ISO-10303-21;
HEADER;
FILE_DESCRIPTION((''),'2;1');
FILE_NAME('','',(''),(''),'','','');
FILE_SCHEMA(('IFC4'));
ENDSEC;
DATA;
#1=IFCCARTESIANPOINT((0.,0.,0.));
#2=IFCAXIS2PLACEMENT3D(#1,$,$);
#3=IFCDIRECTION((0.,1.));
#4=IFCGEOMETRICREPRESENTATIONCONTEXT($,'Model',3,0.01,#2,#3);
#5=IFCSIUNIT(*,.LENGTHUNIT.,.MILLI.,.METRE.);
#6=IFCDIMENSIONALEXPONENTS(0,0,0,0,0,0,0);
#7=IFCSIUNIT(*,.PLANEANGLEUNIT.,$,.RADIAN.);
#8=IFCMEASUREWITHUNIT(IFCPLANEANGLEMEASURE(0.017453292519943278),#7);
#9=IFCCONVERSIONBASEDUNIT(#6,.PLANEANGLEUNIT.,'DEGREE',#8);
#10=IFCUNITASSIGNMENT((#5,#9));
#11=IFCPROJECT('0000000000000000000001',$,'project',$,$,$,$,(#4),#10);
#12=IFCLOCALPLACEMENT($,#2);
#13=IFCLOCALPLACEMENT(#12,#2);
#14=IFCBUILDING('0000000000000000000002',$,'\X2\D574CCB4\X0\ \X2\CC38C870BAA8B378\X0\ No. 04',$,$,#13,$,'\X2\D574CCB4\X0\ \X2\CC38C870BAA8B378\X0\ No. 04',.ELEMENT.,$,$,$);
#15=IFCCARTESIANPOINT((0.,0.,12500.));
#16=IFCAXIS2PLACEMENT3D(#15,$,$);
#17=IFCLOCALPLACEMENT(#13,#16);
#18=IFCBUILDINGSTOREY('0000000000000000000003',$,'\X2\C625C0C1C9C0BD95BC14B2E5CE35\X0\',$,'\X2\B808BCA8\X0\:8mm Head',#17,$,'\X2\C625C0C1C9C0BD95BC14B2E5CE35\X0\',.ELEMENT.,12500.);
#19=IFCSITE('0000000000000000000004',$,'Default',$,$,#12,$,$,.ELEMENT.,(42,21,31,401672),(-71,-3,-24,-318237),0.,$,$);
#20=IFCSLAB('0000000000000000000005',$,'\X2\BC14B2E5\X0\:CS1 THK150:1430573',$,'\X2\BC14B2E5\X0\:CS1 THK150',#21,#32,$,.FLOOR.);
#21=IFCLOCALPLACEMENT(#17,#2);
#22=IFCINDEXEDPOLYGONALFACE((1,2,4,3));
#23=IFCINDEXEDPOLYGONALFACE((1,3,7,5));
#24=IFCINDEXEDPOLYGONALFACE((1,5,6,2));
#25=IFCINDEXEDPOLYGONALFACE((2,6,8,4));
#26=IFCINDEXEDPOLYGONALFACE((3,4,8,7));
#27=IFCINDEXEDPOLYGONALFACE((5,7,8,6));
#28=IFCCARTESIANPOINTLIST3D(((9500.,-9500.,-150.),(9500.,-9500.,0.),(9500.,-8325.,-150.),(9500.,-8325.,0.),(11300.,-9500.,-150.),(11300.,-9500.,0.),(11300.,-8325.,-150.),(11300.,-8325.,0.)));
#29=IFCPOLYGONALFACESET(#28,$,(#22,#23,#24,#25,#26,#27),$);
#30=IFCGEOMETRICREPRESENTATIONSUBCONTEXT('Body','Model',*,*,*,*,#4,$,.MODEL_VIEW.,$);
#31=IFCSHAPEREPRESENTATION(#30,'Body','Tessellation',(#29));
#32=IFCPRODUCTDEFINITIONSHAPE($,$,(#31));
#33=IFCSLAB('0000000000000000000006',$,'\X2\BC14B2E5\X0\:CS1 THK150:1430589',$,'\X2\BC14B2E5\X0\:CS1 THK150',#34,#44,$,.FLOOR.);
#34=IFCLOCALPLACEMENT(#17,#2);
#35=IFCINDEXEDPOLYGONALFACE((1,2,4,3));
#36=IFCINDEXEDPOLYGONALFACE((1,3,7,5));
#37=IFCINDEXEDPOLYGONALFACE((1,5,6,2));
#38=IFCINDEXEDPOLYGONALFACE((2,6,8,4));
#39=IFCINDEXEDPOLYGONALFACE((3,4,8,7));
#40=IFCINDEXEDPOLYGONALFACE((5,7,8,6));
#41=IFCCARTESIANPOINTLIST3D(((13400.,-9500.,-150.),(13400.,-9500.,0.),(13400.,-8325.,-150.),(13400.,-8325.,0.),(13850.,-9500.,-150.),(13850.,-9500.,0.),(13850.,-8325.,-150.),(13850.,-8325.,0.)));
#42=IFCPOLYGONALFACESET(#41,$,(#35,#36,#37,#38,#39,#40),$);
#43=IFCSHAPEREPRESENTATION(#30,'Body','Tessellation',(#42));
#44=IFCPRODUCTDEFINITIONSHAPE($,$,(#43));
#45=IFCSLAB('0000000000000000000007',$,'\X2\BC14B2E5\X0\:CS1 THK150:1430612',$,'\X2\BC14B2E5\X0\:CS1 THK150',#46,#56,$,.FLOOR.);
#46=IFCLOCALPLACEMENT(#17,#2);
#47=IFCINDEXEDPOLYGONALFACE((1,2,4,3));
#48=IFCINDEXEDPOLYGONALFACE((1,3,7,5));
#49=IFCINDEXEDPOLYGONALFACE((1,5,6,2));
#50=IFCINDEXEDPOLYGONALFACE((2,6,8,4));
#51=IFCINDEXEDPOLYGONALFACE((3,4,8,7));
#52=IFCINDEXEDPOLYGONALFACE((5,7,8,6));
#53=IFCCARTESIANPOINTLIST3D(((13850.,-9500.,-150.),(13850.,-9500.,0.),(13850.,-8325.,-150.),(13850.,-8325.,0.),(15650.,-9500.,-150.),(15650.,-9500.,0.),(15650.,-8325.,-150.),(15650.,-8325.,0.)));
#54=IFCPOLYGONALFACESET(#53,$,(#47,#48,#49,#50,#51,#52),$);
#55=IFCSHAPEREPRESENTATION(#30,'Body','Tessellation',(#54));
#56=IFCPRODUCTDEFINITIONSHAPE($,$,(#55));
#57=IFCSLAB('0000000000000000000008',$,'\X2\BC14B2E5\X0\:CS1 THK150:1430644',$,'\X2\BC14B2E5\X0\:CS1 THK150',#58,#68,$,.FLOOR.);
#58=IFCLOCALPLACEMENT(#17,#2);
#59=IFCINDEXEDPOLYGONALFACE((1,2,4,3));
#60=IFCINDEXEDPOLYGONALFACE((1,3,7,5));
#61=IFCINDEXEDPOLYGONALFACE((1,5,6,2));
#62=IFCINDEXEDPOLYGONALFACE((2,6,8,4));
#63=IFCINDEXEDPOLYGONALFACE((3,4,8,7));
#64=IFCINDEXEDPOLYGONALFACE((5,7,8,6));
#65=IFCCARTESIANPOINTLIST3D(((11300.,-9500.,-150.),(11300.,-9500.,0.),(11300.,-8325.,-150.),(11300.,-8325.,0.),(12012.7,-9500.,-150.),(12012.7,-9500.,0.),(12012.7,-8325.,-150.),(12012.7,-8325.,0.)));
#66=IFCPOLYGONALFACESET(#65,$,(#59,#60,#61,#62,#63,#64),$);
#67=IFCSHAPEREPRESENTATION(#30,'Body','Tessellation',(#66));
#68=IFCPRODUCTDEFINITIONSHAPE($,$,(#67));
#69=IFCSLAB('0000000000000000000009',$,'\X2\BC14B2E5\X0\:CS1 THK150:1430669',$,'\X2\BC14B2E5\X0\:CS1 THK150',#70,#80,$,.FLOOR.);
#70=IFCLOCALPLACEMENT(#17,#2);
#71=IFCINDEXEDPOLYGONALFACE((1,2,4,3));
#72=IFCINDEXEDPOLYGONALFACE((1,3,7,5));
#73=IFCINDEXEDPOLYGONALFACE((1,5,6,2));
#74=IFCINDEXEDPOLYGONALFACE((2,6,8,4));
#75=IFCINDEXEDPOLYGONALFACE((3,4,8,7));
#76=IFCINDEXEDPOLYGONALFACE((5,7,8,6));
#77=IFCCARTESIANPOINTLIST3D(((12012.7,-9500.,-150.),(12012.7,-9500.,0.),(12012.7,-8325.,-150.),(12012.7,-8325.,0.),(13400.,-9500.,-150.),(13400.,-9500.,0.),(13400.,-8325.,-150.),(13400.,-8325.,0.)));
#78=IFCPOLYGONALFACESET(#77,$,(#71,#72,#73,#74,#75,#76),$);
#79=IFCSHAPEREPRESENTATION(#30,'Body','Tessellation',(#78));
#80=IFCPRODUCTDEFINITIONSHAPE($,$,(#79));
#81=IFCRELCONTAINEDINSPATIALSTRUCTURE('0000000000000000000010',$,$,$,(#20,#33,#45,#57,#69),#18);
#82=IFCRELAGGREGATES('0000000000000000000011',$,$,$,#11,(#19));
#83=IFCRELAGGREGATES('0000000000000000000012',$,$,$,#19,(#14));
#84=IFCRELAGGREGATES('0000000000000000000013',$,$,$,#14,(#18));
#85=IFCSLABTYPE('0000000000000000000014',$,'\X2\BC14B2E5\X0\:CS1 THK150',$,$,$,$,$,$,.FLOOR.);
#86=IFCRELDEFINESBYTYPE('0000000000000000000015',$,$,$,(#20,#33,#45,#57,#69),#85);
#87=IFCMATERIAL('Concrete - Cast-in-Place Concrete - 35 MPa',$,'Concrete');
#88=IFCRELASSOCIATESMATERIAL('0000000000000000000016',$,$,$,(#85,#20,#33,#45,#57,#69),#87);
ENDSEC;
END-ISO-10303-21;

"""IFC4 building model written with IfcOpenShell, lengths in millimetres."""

from ifc_helpers import new_model, entity, si_unit, converted_unit, direction, frame, origin, place, context, subcontext, project, spatial, indexed_curve, outline, extrude, material, type_object, element, save


model = new_model("IFC4")

# Units and contexts
model_context = context("Model", 3, precision=0.01, world=origin(), true_north=direction((0.0, 1.0)))
body_context = subcontext(model_context, "Body", "Model", "MODEL_VIEW")
ifc_project = project(units=[si_unit("LENGTHUNIT", "METRE", prefix="MILLI"), converted_unit("PLANEANGLEUNIT", "DEGREE", entity("IfcPlaneAngleMeasure", 0.017453292519943278), si_unit("PLANEANGLEUNIT", "RADIAN"), dimensions=[0, 0, 0, 0, 0, 0, 0])], contexts=[model_context])

# Site, building, storey
site_placement = place(None, origin())
site = spatial("IfcSite", under=ifc_project, at=site_placement, Name="Default", CompositionType="ELEMENT", RefLatitude=(42, 21, 31, 401672), RefLongitude=(-71, -3, -24, -318237), RefElevation=0.0)
building_placement = place(site_placement, origin())
building = spatial("IfcBuilding", under=site, at=building_placement, Name="해체 참조모델 No. 04", LongName="해체 참조모델 No. 04", CompositionType="ELEMENT")
storey_placement = place(building_placement, frame((0.0, 0.0, 12500.0)))
storey = spatial("IfcBuildingStorey", under=building, at=storey_placement, Name="옥상지붕바닥층", ObjectType="레벨:8mm Head", LongName="옥상지붕바닥층", CompositionType="ELEMENT", Elevation=12500.0)

# Slabs
ifc_material = material(Name="Concrete - Cast-in-Place Concrete - 35 MPa", Category="Concrete")
slab_type_1 = type_object("IfcSlabType", Name="바닥:CS1 THK150", PredefinedType="FLOOR", material=ifc_material)
slab_1_placement = place(storey_placement, origin())
element("IfcSlab", 1, at=slab_1_placement, inside=storey, type_object=slab_type_1, material=ifc_material, Name="바닥:CS1 THK150:1430573", ObjectType="바닥:CS1 THK150", PredefinedType="FLOOR", context=body_context, shape_type="SweptSolid", body=[
    extrude(outline(indexed_curve([(-587.5, -900.0), (587.5, -900.0), (587.5, 900.0), (-587.5, 900.0), (-587.5, -900.0)], self_intersect=False)), frame((10400.0, -8912.5, 0.0), z_axis=(0.0, 0.0, -1.0), x_axis=(0.0, 1.0, 0.0)), (0.0, 0.0, 1.0), 150.0),
])
slab_2_placement = place(storey_placement, origin())
element("IfcSlab", 2, at=slab_2_placement, inside=storey, type_object=slab_type_1, material=ifc_material, Name="바닥:CS1 THK150:1430589", ObjectType="바닥:CS1 THK150", PredefinedType="FLOOR", context=body_context, shape_type="SweptSolid", body=[
    extrude(outline(indexed_curve([(-587.5, -225.0), (587.5, -225.0), (587.5, 225.0), (-587.5, 225.0), (-587.5, -225.0)], self_intersect=False)), frame((13625.0, -8912.5, 0.0), z_axis=(0.0, 0.0, -1.0), x_axis=(0.0, 1.0, 0.0)), (0.0, 0.0, 1.0), 150.0),
])
slab_3_placement = place(storey_placement, origin())
element("IfcSlab", 3, at=slab_3_placement, inside=storey, type_object=slab_type_1, material=ifc_material, Name="바닥:CS1 THK150:1430612", ObjectType="바닥:CS1 THK150", PredefinedType="FLOOR", context=body_context, shape_type="SweptSolid", body=[
    extrude(outline(indexed_curve([(-587.5, -900.0), (587.5, -900.0), (587.5, 900.0), (-587.5, 900.0), (-587.5, -900.0)], self_intersect=False)), frame((14750.0, -8912.5, 0.0), z_axis=(0.0, 0.0, -1.0), x_axis=(0.0, 1.0, 0.0)), (0.0, 0.0, 1.0), 150.0),
])
slab_4_placement = place(storey_placement, origin())
element("IfcSlab", 4, at=slab_4_placement, inside=storey, type_object=slab_type_1, material=ifc_material, Name="바닥:CS1 THK150:1430644", ObjectType="바닥:CS1 THK150", PredefinedType="FLOOR", context=body_context, shape_type="SweptSolid", body=[
    extrude(outline(indexed_curve([(-587.5, -356.4), (587.5, -356.4), (587.5, 356.4), (-587.5, 356.4), (-587.5, -356.4)], self_intersect=False)), frame((11656.4, -8912.5, 0.0), z_axis=(0.0, 0.0, -1.0), x_axis=(0.0, 1.0, 0.0)), (0.0, 0.0, 1.0), 150.0),
])
slab_5_placement = place(storey_placement, origin())
element("IfcSlab", 5, at=slab_5_placement, inside=storey, type_object=slab_type_1, material=ifc_material, Name="바닥:CS1 THK150:1430669", ObjectType="바닥:CS1 THK150", PredefinedType="FLOOR", context=body_context, shape_type="SweptSolid", body=[
    extrude(outline(indexed_curve([(-587.5, -693.6), (587.5, -693.6), (587.5, 693.6), (-587.5, 693.6), (-587.5, -693.6)], self_intersect=False)), frame((12706.4, -8912.5, 0.0), z_axis=(0.0, 0.0, -1.0), x_axis=(0.0, 1.0, 0.0)), (0.0, 0.0, 1.0), 150.0),
])

save(model, "model.ifc")
